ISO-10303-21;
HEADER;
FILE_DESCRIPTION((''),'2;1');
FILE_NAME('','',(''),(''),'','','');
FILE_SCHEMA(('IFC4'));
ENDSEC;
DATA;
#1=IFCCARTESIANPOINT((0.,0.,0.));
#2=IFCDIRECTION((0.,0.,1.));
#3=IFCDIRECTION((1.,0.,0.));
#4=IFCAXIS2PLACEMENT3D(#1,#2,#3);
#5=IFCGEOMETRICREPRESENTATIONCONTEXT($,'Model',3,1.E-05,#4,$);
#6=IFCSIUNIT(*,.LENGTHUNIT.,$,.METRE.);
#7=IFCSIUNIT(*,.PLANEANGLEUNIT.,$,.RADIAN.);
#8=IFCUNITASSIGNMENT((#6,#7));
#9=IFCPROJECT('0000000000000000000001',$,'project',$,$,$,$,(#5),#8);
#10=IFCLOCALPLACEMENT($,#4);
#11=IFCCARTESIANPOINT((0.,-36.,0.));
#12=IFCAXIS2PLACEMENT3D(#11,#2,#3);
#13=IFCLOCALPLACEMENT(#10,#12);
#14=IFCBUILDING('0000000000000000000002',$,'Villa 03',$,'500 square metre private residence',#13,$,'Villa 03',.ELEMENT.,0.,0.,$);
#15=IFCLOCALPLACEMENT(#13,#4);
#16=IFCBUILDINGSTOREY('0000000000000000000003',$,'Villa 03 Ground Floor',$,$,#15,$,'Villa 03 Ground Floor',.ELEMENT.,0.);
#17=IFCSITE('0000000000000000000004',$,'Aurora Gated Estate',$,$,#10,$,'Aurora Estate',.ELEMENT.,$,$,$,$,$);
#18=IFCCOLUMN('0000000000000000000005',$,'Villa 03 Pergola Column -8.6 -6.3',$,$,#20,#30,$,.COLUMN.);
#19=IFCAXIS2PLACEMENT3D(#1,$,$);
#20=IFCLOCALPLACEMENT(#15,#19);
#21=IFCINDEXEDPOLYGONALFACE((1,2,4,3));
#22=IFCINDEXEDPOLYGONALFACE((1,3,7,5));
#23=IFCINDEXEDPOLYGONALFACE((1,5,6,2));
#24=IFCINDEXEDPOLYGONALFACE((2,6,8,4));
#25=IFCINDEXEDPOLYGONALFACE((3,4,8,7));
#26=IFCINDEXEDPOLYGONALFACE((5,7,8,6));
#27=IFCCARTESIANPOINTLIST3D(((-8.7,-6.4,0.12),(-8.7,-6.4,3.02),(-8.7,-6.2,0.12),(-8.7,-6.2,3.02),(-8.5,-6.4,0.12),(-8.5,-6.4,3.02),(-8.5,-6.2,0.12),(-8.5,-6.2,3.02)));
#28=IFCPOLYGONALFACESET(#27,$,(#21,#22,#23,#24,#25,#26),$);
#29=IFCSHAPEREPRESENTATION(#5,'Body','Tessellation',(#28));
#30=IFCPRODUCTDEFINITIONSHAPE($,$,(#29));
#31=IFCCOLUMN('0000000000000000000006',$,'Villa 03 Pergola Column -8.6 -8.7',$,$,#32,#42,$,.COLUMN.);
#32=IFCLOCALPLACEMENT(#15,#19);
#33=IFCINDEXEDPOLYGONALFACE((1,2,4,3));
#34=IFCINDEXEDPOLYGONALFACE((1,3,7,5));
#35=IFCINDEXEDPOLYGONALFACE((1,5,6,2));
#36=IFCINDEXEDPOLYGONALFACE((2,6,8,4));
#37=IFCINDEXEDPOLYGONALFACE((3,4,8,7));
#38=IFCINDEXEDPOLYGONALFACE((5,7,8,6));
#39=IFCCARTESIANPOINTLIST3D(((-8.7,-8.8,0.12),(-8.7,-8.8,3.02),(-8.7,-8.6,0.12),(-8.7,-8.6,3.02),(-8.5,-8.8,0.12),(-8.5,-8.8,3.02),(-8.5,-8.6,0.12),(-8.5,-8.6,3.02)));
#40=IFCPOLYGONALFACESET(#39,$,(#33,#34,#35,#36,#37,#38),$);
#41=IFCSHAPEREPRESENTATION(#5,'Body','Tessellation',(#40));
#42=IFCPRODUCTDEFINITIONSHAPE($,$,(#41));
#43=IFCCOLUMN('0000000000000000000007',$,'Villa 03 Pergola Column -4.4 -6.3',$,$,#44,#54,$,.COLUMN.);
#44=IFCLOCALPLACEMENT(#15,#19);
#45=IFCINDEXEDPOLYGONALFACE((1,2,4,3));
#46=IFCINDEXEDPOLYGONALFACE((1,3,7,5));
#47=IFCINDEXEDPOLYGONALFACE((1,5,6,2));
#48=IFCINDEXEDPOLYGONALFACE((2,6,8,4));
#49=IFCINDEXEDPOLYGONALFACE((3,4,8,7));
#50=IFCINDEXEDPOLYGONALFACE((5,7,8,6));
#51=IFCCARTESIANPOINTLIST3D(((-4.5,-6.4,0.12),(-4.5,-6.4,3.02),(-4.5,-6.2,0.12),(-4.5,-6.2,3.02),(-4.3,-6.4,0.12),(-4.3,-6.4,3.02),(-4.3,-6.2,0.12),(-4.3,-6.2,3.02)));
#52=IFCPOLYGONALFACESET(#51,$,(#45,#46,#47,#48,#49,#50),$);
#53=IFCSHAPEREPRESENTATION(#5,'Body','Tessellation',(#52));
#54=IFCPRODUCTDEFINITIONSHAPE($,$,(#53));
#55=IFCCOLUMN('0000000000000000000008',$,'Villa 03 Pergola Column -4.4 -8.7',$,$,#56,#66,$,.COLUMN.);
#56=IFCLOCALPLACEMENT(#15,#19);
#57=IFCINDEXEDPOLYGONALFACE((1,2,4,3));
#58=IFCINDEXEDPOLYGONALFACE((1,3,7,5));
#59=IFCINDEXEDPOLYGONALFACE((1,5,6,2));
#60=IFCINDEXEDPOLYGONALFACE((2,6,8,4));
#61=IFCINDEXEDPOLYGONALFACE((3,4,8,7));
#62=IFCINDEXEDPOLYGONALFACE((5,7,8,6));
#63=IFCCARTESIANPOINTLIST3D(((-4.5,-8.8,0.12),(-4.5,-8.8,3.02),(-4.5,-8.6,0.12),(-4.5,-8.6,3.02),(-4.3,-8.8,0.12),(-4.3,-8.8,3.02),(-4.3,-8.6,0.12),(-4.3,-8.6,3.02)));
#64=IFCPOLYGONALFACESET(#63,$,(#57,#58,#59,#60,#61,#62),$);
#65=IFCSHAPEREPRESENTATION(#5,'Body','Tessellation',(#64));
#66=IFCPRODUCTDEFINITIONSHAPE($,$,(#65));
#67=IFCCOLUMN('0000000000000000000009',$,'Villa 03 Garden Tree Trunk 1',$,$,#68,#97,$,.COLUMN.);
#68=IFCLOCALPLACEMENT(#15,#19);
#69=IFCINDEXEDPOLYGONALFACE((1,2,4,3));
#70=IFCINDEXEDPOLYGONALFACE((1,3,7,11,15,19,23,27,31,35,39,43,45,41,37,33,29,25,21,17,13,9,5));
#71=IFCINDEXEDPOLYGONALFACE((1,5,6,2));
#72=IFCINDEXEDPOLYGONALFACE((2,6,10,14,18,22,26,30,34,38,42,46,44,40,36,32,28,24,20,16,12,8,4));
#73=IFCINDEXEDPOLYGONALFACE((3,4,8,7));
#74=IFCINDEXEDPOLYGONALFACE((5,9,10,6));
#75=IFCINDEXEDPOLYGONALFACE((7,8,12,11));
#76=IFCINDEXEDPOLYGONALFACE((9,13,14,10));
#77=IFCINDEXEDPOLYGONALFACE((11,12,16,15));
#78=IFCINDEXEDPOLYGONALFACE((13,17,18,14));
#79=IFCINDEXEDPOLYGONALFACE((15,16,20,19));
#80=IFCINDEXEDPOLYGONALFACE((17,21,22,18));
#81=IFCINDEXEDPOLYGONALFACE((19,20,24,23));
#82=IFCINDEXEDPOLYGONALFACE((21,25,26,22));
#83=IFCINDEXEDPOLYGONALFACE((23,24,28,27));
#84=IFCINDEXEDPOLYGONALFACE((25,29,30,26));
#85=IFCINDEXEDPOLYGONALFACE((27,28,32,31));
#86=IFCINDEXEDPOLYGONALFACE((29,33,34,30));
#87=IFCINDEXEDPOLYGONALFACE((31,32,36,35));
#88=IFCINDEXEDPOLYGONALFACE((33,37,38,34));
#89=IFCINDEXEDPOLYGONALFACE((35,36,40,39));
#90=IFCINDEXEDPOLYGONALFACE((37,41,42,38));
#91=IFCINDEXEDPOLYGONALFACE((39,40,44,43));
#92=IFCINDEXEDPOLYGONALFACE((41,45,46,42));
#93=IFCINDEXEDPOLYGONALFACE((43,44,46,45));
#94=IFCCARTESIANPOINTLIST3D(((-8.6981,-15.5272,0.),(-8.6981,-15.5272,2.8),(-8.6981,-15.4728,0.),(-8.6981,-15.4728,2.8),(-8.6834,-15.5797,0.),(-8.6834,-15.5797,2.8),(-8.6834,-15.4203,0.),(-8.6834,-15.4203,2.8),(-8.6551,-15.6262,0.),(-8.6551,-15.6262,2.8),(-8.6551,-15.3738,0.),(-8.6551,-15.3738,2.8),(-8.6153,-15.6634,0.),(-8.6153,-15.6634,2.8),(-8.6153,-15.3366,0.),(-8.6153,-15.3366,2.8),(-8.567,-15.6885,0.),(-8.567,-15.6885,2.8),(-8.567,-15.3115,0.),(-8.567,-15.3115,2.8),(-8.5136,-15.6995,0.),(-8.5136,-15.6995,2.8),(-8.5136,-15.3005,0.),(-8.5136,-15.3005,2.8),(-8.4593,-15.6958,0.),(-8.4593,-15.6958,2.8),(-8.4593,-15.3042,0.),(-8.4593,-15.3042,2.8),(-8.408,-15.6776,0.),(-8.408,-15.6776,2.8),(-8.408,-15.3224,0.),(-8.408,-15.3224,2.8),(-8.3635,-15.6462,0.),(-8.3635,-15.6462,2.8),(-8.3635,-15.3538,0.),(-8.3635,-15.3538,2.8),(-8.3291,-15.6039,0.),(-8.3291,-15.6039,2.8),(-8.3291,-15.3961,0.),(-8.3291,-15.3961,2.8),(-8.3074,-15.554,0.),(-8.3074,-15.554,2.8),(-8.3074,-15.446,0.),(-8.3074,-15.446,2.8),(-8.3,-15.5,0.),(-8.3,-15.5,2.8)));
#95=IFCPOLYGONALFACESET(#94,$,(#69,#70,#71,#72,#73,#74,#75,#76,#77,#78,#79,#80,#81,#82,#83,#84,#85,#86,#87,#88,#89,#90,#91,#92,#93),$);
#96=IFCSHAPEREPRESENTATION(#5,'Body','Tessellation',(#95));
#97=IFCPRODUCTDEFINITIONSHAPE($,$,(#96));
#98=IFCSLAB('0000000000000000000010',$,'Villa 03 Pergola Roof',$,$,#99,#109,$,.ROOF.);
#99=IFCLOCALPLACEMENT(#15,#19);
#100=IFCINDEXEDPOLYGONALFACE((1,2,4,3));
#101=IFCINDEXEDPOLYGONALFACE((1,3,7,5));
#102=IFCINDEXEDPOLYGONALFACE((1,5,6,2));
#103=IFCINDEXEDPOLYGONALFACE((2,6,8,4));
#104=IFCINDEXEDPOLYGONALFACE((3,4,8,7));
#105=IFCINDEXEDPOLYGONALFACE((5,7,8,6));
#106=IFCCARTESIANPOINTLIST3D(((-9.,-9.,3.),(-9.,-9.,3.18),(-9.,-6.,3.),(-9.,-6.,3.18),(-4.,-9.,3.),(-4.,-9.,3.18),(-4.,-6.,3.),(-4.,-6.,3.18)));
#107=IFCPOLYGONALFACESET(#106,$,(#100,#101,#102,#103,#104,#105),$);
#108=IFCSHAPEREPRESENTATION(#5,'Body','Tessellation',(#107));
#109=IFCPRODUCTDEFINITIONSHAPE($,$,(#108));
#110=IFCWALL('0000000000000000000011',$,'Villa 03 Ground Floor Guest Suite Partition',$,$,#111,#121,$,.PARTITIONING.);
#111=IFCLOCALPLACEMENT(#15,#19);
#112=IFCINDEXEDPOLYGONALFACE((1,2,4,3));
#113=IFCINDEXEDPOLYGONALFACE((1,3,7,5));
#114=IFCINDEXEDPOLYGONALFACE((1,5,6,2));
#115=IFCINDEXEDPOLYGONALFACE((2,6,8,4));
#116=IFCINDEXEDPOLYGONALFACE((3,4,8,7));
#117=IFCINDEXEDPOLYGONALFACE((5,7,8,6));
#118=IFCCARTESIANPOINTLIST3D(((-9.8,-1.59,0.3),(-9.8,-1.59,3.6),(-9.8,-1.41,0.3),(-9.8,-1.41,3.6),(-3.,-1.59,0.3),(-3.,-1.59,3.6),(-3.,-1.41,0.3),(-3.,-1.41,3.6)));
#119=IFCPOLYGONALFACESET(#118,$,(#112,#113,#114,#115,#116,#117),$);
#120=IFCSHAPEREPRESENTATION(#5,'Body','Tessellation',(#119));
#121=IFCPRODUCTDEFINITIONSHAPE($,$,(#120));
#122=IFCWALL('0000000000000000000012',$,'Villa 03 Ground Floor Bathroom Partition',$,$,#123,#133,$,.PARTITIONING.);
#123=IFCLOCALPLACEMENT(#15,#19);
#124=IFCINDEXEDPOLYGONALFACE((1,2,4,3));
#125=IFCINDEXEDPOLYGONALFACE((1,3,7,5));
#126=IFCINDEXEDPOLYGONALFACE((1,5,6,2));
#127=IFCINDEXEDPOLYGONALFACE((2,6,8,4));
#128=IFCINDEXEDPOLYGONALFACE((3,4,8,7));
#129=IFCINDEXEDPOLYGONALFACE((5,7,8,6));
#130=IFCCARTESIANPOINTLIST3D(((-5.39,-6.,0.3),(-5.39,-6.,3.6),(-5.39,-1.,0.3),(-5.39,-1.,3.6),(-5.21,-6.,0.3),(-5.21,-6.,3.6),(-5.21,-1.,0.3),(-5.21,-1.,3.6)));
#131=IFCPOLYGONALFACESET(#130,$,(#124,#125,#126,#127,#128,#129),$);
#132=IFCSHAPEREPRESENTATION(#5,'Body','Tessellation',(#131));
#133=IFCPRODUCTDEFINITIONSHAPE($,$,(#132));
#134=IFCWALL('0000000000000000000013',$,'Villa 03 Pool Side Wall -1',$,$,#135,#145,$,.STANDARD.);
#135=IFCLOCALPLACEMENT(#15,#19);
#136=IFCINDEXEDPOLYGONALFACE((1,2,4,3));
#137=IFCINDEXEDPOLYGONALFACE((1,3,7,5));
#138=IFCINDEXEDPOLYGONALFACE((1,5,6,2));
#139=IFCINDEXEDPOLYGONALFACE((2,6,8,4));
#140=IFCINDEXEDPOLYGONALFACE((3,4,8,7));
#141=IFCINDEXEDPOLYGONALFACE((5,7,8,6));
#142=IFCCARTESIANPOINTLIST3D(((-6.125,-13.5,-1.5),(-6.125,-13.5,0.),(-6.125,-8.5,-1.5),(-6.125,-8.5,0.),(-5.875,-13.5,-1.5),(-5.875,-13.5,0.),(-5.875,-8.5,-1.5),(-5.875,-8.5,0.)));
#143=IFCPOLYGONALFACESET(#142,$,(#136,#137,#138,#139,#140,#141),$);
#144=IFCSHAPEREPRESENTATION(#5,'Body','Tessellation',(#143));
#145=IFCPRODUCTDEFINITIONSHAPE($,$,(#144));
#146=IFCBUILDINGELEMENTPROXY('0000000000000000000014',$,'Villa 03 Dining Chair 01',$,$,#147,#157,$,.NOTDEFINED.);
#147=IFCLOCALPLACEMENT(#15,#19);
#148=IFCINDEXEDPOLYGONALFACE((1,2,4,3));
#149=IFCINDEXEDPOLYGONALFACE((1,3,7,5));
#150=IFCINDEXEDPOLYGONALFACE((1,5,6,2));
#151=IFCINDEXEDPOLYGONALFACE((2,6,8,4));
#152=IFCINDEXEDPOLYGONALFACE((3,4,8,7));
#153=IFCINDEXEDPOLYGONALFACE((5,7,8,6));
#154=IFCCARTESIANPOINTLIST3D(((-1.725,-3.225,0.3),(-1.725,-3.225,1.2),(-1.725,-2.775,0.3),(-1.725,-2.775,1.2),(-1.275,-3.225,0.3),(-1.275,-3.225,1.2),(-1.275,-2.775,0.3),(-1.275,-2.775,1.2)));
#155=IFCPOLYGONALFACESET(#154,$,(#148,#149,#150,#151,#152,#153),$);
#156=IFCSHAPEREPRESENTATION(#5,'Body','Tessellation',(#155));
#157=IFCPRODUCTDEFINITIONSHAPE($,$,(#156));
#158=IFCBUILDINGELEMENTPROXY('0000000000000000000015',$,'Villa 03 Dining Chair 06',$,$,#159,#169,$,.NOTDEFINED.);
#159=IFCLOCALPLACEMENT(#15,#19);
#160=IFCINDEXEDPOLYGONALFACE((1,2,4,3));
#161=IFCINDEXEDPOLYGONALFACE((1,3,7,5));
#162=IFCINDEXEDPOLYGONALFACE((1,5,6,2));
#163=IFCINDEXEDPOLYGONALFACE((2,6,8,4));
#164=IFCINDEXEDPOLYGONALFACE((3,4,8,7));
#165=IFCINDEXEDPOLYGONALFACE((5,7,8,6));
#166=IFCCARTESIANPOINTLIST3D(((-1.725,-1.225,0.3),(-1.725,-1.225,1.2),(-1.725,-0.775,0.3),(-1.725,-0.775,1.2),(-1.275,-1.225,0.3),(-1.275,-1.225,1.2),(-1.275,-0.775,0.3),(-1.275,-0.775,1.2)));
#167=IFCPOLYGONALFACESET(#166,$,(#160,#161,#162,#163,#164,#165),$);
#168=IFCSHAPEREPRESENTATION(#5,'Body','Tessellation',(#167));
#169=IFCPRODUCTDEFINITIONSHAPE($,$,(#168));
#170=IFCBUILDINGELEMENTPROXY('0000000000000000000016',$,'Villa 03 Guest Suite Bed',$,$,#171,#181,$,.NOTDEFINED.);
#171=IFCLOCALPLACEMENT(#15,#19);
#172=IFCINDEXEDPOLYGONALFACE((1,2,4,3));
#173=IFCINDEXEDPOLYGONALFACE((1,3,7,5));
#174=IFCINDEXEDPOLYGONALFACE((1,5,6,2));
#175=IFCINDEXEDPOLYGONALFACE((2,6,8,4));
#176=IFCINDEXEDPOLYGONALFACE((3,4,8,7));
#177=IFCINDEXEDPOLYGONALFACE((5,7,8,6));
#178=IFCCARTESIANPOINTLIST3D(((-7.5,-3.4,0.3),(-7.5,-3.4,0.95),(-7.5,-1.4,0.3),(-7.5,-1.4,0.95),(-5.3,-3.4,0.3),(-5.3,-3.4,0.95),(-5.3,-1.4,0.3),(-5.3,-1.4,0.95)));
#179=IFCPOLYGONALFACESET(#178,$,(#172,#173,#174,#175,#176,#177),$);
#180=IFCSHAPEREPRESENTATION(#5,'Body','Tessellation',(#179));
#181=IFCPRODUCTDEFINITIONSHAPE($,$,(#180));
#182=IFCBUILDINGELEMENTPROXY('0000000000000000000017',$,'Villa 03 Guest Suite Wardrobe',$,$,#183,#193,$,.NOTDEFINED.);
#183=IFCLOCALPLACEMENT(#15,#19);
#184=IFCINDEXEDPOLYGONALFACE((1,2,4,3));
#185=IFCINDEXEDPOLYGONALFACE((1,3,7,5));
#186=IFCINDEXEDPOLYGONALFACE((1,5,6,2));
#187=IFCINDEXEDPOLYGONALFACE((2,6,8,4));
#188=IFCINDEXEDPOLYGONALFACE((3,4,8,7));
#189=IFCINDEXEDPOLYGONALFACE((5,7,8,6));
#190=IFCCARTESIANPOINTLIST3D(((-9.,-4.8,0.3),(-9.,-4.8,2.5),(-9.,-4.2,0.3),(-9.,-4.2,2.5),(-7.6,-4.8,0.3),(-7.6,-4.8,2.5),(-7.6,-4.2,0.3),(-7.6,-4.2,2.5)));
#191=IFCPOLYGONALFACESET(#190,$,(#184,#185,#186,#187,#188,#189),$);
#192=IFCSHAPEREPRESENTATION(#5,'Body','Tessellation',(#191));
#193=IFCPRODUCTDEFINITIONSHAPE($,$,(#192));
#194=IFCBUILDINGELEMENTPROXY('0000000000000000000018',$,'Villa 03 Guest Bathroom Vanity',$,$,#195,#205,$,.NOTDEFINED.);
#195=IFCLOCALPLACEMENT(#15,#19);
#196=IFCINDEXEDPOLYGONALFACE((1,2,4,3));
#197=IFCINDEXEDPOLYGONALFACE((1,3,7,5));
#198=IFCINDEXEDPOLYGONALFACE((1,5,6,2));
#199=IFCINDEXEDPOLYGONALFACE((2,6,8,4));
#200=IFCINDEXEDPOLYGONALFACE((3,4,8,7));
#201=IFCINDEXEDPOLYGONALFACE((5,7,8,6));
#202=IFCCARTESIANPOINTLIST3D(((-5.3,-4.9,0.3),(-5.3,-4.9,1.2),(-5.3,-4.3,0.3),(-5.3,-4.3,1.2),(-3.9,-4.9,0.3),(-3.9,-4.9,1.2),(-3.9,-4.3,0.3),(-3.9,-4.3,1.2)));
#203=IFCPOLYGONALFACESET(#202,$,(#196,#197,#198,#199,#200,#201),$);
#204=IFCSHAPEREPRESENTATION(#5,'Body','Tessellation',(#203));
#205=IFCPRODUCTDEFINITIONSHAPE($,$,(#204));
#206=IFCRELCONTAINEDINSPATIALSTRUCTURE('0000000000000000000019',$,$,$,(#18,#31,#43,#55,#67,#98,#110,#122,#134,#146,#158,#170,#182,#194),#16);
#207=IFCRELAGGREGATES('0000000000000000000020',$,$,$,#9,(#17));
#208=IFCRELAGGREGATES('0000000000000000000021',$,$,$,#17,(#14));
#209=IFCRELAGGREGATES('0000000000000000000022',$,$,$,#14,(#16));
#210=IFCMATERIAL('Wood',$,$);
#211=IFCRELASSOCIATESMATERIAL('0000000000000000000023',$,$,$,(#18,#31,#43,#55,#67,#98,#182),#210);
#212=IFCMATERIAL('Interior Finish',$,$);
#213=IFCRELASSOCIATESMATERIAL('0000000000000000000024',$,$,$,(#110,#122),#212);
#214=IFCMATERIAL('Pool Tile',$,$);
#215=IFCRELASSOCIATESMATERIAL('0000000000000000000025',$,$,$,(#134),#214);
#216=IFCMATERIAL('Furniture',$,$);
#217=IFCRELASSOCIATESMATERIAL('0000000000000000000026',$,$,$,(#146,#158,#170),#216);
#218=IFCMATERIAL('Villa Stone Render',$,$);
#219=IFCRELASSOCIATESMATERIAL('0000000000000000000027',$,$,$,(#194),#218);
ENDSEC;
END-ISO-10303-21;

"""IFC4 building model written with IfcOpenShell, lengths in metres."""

from ifc_helpers import new_model, si_unit, frame, origin_with_axes, origin_2d_with_axis, place, context, project, spatial, rectangle, circle, extrude, material, element, save


model = new_model("IFC4")

# Units and contexts
model_context = context("Model", 3, precision=1e-05, world=origin_with_axes())
ifc_project = project(units=[si_unit("LENGTHUNIT", "METRE"), si_unit("PLANEANGLEUNIT", "RADIAN")], contexts=[model_context])

# Site, building, storey
site_placement = place(None, origin_with_axes())
site = spatial("IfcSite", under=ifc_project, at=site_placement, Name="Aurora Gated Estate", LongName="Aurora Estate", CompositionType="ELEMENT")
building_placement = place(site_placement, frame((0.0, -36.0, 0.0), z_axis=(0.0, 0.0, 1.0), x_axis=(1.0, 0.0, 0.0)))
building = spatial("IfcBuilding", under=site, at=building_placement, Name="Villa 03", ObjectType="500 square metre private residence", LongName="Villa 03", CompositionType="ELEMENT", ElevationOfRefHeight=0.0, ElevationOfTerrain=0.0)
storey_placement = place(building_placement, origin_with_axes())
storey = spatial("IfcBuildingStorey", under=building, at=storey_placement, Name="Villa 03 Ground Floor", LongName="Villa 03 Ground Floor", CompositionType="ELEMENT", Elevation=0.0)

# Columns
ifc_material_1 = material(Name="Wood")
for number, where, z_axis, x_axis, name in (
    (1, (-8.6, -6.3, 0.12), (0.0, 0.0, 1.0), (1.0, 0.0, 0.0), "Villa 03 Pergola Column -8.6 -6.3"),
    (2, (-8.6, -8.7, 0.12), (0.0, 0.0, 1.0), (1.0, 0.0, 0.0), "Villa 03 Pergola Column -8.6 -8.7"),
    (3, (-4.4, -6.3, 0.12), (0.0, 0.0, 1.0), (1.0, 0.0, 0.0), "Villa 03 Pergola Column -4.4 -6.3"),
    (4, (-4.4, -8.7, 0.12), (0.0, 0.0, 1.0), (1.0, 0.0, 0.0), "Villa 03 Pergola Column -4.4 -8.7"),
):
    element("IfcColumn", number, at=place(storey_placement, frame(where, z_axis=z_axis, x_axis=x_axis)), inside=storey, material=ifc_material_1, Name=name, PredefinedType="COLUMN", context=model_context, shape_type="SweptSolid", body=[
        extrude(rectangle(XDim=0.2, YDim=0.2, at=origin_2d_with_axis()), origin_with_axes(), (0.0, 0.0, 1.0), 2.9),
    ])
column_placement = place(storey_placement, frame((-8.5, -15.5, 0.0), z_axis=(0.0, 0.0, 1.0), x_axis=(1.0, 0.0, 0.0)))
element("IfcColumn", 5, at=column_placement, inside=storey, material=ifc_material_1, Name="Villa 03 Garden Tree Trunk 1", PredefinedType="COLUMN", context=model_context, shape_type="SweptSolid", body=[
    extrude(circle(Radius=0.2, at=origin_2d_with_axis()), origin_with_axes(), (0.0, 0.0, 1.0), 2.8),
])

# Slab
slab_placement = place(storey_placement, frame((-6.5, -7.5, 3.0), z_axis=(0.0, 0.0, 1.0), x_axis=(1.0, 0.0, 0.0)))
element("IfcSlab", 6, at=slab_placement, inside=storey, material=ifc_material_1, Name="Villa 03 Pergola Roof", PredefinedType="ROOF", context=model_context, shape_type="SweptSolid", body=[
    extrude(rectangle(XDim=5.0, YDim=3.0, at=origin_2d_with_axis()), origin_with_axes(), (0.0, 0.0, 1.0), 0.18),
])

# Walls
ifc_material_2 = material(Name="Interior Finish")
wall_1_placement = place(storey_placement, frame((-6.4, -1.5, 0.3), z_axis=(0.0, 0.0, 1.0), x_axis=(1.0, 0.0, 0.0)))
element("IfcWall", 7, at=wall_1_placement, inside=storey, material=ifc_material_2, Name="Villa 03 Ground Floor Guest Suite Partition", PredefinedType="PARTITIONING", context=model_context, shape_type="SweptSolid", body=[
    extrude(rectangle(XDim=6.8, YDim=0.18, at=origin_2d_with_axis()), origin_with_axes(), (0.0, 0.0, 1.0), 3.3),
])
wall_2_placement = place(storey_placement, frame((-5.3, -3.5, 0.3), z_axis=(0.0, 0.0, 1.0), x_axis=(1.0, 0.0, 0.0)))
element("IfcWall", 8, at=wall_2_placement, inside=storey, material=ifc_material_2, Name="Villa 03 Ground Floor Bathroom Partition", PredefinedType="PARTITIONING", context=model_context, shape_type="SweptSolid", body=[
    extrude(rectangle(XDim=0.18, YDim=5.0, at=origin_2d_with_axis()), origin_with_axes(), (0.0, 0.0, 1.0), 3.3),
])
ifc_material_3 = material(Name="Pool Tile")
wall_3_placement = place(storey_placement, frame((-6.0, -11.0, -1.5), z_axis=(0.0, 0.0, 1.0), x_axis=(1.0, 0.0, 0.0)))
element("IfcWall", 9, at=wall_3_placement, inside=storey, material=ifc_material_3, Name="Villa 03 Pool Side Wall -1", PredefinedType="STANDARD", context=model_context, shape_type="SweptSolid", body=[
    extrude(rectangle(XDim=0.25, YDim=5.0, at=origin_2d_with_axis()), origin_with_axes(), (0.0, 0.0, 1.0), 1.5),
])

# Building element proxies
ifc_material_4 = material(Name="Furniture")
for number, where, z_axis, x_axis, name in (
    (10, (-1.5, -3.0, 0.3), (0.0, 0.0, 1.0), (1.0, 0.0, 0.0), "Villa 03 Dining Chair 01"),
    (11, (-1.5, -1.0, 0.3), (0.0, 0.0, 1.0), (1.0, 0.0, 0.0), "Villa 03 Dining Chair 06"),
):
    element("IfcBuildingElementProxy", number, at=place(storey_placement, frame(where, z_axis=z_axis, x_axis=x_axis)), inside=storey, material=ifc_material_4, Name=name, PredefinedType="NOTDEFINED", context=model_context, shape_type="SweptSolid", body=[
        extrude(rectangle(XDim=0.45, YDim=0.45, at=origin_2d_with_axis()), origin_with_axes(), (0.0, 0.0, 1.0), 0.9),
    ])
proxy_1_placement = place(storey_placement, frame((-6.4, -2.4, 0.3), z_axis=(0.0, 0.0, 1.0), x_axis=(1.0, 0.0, 0.0)))
element("IfcBuildingElementProxy", 12, at=proxy_1_placement, inside=storey, material=ifc_material_4, Name="Villa 03 Guest Suite Bed", PredefinedType="NOTDEFINED", context=model_context, shape_type="SweptSolid", body=[
    extrude(rectangle(XDim=2.2, YDim=2.0, at=origin_2d_with_axis()), origin_with_axes(), (0.0, 0.0, 1.0), 0.65),
])
proxy_2_placement = place(storey_placement, frame((-8.3, -4.5, 0.3), z_axis=(0.0, 0.0, 1.0), x_axis=(1.0, 0.0, 0.0)))
element("IfcBuildingElementProxy", 13, at=proxy_2_placement, inside=storey, material=ifc_material_1, Name="Villa 03 Guest Suite Wardrobe", PredefinedType="NOTDEFINED", context=model_context, shape_type="SweptSolid", body=[
    extrude(rectangle(XDim=1.4, YDim=0.6, at=origin_2d_with_axis()), origin_with_axes(), (0.0, 0.0, 1.0), 2.2),
])
ifc_material_5 = material(Name="Villa Stone Render")
proxy_3_placement = place(storey_placement, frame((-4.6, -4.6, 0.3), z_axis=(0.0, 0.0, 1.0), x_axis=(1.0, 0.0, 0.0)))
element("IfcBuildingElementProxy", 14, at=proxy_3_placement, inside=storey, material=ifc_material_5, Name="Villa 03 Guest Bathroom Vanity", PredefinedType="NOTDEFINED", context=model_context, shape_type="SweptSolid", body=[
    extrude(rectangle(XDim=1.4, YDim=0.6, at=origin_2d_with_axis()), origin_with_axes(), (0.0, 0.0, 1.0), 0.9),
])

save(model, "model.ifc")
